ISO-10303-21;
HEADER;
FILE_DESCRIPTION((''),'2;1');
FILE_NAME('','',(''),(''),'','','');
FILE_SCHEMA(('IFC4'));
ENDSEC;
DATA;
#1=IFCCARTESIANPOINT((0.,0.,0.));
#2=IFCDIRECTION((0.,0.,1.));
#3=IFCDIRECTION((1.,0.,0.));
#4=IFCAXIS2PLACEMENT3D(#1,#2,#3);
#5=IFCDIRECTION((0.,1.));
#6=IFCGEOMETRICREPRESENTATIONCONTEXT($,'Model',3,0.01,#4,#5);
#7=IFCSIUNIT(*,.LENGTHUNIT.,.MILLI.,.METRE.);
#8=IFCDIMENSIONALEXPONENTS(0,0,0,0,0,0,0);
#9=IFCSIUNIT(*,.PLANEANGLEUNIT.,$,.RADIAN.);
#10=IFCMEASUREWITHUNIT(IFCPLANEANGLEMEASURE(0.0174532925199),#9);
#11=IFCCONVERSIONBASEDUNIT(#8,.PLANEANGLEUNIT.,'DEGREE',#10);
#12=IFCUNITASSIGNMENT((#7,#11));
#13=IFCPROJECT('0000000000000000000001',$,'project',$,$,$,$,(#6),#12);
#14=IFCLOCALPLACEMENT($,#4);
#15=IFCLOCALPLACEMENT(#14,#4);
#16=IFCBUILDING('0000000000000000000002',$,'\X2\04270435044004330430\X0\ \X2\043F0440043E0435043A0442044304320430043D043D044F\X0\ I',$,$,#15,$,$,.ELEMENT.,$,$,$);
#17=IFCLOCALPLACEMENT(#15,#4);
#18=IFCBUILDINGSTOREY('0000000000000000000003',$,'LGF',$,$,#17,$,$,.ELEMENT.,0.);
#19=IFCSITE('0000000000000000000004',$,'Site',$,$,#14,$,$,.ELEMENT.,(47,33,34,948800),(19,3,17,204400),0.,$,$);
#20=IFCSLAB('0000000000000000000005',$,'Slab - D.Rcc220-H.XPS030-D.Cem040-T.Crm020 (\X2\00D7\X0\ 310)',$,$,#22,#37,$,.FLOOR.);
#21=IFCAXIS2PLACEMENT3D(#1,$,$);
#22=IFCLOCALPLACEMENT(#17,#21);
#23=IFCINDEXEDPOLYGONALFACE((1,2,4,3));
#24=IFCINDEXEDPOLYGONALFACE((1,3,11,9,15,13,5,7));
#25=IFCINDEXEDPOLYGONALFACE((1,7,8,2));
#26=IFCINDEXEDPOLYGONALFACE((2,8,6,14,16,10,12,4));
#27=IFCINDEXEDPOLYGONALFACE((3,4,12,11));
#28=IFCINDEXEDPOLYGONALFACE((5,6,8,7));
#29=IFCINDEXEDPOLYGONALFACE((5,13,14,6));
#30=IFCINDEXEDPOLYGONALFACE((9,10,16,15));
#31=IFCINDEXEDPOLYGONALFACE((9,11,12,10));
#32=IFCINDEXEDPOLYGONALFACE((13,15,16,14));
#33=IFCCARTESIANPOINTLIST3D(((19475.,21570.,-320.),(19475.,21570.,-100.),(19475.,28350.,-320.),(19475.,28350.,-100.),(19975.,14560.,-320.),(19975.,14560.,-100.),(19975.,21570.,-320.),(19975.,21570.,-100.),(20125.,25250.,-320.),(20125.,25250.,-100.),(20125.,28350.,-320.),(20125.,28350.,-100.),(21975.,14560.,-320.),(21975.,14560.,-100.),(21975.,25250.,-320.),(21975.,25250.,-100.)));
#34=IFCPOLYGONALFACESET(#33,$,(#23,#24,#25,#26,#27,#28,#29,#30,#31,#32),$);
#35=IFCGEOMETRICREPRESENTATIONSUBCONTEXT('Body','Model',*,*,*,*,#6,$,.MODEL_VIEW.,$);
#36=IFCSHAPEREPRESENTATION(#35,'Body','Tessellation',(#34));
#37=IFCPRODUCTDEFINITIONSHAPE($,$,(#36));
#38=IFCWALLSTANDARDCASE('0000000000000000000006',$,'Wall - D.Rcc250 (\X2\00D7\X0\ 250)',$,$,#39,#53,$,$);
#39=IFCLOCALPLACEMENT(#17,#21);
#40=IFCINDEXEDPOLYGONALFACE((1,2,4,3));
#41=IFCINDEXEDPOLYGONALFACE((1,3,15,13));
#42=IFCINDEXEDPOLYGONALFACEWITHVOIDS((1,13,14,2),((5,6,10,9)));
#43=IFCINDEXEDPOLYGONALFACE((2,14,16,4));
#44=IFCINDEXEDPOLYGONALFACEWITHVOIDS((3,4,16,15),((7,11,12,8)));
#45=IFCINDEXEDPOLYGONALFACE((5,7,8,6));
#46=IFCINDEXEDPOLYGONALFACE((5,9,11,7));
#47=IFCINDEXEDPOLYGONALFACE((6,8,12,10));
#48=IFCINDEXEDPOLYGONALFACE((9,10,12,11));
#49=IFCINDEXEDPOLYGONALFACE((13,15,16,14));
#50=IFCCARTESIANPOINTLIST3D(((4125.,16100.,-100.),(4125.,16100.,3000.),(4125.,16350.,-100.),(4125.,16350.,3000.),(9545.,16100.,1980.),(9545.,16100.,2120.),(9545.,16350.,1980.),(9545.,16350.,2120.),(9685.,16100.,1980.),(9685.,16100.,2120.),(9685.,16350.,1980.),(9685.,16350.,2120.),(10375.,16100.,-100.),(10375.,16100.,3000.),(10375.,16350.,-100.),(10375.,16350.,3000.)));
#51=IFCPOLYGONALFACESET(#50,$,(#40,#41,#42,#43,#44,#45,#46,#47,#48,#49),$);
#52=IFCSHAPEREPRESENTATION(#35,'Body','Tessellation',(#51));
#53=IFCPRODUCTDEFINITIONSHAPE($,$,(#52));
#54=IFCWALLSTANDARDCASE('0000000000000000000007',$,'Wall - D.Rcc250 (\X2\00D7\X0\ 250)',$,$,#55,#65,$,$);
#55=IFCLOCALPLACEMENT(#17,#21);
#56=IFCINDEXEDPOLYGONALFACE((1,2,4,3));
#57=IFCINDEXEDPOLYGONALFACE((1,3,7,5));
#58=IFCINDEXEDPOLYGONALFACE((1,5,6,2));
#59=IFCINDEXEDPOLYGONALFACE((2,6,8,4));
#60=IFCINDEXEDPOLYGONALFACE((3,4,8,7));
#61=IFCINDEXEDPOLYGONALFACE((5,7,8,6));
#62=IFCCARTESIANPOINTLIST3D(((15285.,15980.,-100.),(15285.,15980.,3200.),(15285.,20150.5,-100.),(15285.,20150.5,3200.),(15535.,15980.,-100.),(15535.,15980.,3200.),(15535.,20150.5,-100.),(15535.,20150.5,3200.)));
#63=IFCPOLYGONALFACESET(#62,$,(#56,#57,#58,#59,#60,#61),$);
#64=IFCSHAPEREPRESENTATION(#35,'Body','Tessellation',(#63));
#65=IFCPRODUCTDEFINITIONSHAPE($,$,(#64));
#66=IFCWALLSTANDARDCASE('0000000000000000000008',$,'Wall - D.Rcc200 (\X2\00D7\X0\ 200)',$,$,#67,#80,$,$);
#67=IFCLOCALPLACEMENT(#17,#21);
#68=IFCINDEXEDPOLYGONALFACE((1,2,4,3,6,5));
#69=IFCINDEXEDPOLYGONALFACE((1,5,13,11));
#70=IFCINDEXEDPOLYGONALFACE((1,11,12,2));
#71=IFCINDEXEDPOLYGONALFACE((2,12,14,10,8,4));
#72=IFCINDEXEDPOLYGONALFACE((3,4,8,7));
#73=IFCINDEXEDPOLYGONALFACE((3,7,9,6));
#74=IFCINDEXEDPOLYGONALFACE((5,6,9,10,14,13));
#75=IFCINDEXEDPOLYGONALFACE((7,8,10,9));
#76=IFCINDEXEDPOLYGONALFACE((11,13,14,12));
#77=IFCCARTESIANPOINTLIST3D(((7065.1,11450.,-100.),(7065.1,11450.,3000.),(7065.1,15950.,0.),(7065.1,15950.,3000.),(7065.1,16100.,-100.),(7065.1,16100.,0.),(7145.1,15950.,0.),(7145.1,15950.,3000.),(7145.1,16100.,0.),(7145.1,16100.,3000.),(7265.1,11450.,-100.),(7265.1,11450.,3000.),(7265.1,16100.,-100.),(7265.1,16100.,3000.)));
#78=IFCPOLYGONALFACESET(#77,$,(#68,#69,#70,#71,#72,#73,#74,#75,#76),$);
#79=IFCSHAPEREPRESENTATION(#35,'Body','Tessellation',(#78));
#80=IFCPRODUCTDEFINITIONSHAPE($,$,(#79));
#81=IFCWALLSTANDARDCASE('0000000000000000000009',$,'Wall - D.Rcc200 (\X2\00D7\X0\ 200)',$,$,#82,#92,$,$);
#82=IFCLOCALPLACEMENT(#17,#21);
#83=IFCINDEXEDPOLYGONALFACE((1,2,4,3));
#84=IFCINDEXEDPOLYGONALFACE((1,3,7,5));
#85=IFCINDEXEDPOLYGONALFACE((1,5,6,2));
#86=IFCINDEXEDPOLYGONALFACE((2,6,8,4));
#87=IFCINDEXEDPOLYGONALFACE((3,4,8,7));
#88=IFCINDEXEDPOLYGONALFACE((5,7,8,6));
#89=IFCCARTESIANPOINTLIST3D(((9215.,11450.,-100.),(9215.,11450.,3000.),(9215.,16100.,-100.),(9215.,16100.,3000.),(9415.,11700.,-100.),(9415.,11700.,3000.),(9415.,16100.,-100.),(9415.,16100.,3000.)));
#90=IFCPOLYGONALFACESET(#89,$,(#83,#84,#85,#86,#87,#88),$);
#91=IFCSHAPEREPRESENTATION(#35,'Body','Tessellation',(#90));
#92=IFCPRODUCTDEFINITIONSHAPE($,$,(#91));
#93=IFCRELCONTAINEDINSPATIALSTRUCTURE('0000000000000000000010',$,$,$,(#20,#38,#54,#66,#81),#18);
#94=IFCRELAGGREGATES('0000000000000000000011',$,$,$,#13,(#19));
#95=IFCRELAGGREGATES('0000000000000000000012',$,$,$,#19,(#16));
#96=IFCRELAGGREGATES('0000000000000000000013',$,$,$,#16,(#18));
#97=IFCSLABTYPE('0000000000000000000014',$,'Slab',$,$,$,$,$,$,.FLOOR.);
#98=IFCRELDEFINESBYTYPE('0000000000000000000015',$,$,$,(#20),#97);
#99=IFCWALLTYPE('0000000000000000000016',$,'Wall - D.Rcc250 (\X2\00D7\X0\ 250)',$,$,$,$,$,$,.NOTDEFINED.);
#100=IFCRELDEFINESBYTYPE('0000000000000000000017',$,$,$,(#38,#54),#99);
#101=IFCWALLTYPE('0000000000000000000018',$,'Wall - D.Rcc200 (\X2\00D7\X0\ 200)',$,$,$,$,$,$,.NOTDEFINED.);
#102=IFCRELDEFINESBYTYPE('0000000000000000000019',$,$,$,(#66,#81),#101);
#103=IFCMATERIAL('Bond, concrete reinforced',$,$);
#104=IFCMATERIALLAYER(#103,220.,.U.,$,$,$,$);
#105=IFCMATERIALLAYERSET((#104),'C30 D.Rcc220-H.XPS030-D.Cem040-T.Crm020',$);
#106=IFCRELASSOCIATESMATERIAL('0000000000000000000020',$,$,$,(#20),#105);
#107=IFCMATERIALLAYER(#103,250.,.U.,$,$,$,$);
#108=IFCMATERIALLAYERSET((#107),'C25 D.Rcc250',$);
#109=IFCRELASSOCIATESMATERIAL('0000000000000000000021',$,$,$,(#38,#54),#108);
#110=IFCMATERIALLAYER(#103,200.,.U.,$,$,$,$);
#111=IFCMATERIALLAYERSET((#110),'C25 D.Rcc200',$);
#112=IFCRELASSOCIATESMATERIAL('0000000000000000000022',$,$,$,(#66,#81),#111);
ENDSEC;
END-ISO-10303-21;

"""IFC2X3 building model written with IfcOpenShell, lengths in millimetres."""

from ifc_helpers import new_model, entity, si_unit, converted_unit, direction, frame, origin_with_axes, origin_2d_with_axis, place, context, subcontext, project, spatial, polyline, rectangle, outline, extrude, material, layer, layer_set, layer_usage, type_object, element, save


model = new_model("IFC2X3")

# Units and contexts
model_context = context("Model", 3, precision=0.01, world=origin_with_axes(), true_north=direction((0.0, 1.0)))
body_context = subcontext(model_context, "Body", "Model", "MODEL_VIEW")
ifc_project = project(units=[si_unit("LENGTHUNIT", "METRE", prefix="MILLI"), converted_unit("PLANEANGLEUNIT", "DEGREE", entity("IfcPlaneAngleMeasure", 0.0174532925199), si_unit("PLANEANGLEUNIT", "RADIAN"), dimensions=[0, 0, 0, 0, 0, 0, 0])], contexts=[model_context])

# Site, building, storey
site_placement = place(None, origin_with_axes())
site = spatial("IfcSite", under=ifc_project, at=site_placement, Name="Site", CompositionType="ELEMENT", RefLatitude=(47, 33, 34, 948800), RefLongitude=(19, 3, 17, 204400), RefElevation=0.0)
building_placement = place(site_placement, origin_with_axes())
building = spatial("IfcBuilding", under=site, at=building_placement, Name="Черга проектування I", CompositionType="ELEMENT")
storey_placement = place(building_placement, origin_with_axes())
storey = spatial("IfcBuildingStorey", under=building, at=storey_placement, Name="LGF", CompositionType="ELEMENT", Elevation=0.0)

# Shared definitions
ifc_material = material(Name="Bond, concrete reinforced")

# Slab
ifc_layer_1 = layer(ifc_material, 220.0, ventilated="UNKNOWN")
ifc_layer_set_1 = layer_set([ifc_layer_1], Name="C30 D.Rcc220-H.XPS030-D.Cem040-T.Crm020")
ifc_layer_usage_1 = layer_usage(ifc_layer_set_1, "AXIS3", "NEGATIVE", 220.0)
slab_type = type_object("IfcSlabType", Name="Slab", PredefinedType="FLOOR")
slab_placement = place(storey_placement, frame((19475.0, 21570.0, -100.0), z_axis=(0.0, 0.0, 1.0), x_axis=(1.0, 0.0, 0.0)))
element("IfcSlab", 1, at=slab_placement, inside=storey, type_object=slab_type, material=ifc_layer_usage_1, Name="Slab - D.Rcc220-H.XPS030-D.Cem040-T.Crm020 (× 310)", PredefinedType="FLOOR", context=body_context, shape_type="SweptSolid", body=[
    extrude(outline(polyline([(0.0, 0.0), (500.0, 0.0), (500.0, -7010.0), (2500.0, -7010.0), (2500.0, 3680.0), (650.0, 3680.0), (650.0, 6780.0), (0.0, 6780.0), (0.0, 0.0)])), frame((0.0, 0.0, -220.0), z_axis=(0.0, 0.0, 1.0), x_axis=(1.0, 0.0, 0.0)), (0.0, 0.0, 1.0), 220.0),
])

# Wall, opening
ifc_layer_2 = layer(ifc_material, 250.0, ventilated="UNKNOWN")
ifc_layer_set_2 = layer_set([ifc_layer_2], Name="C25 D.Rcc250")
ifc_layer_usage_2 = layer_usage(ifc_layer_set_2, "AXIS2", "POSITIVE", -250.0)
wall_type_1 = type_object("IfcWallType", Name="Wall - D.Rcc250 (× 250)", PredefinedType="NOTDEFINED")
wall_1_placement = place(storey_placement, frame((10375.0, 16100.0, -100.0), z_axis=(0.0, 0.0, 1.0), x_axis=(-1.0, 0.0, 0.0)))
wall_1 = element("IfcWallStandardCase", 2, at=wall_1_placement, inside=storey, type_object=wall_type_1, material=ifc_layer_usage_2, Name="Wall - D.Rcc250 (× 250)", context=body_context, shape_type="SweptSolid", body=[
    extrude(outline(polyline([(0.0, -250.0), (6250.0, -250.0), (6250.0, 0.0), (0.0, 0.0), (0.0, -250.0)])), origin_with_axes(), (0.0, 0.0, 1.0), 3100.0),
])
opening_1_placement = place(wall_1_placement, frame((10375.0, 16100.0, 100.0), z_axis=(0.0, 0.0, 1.0), x_axis=(-1.0, 0.0, 0.0)))
element("IfcOpeningElement", 3, at=opening_1_placement, cuts=wall_1, ObjectType="OPENING", context=body_context, shape_type="SweptSolid", body=[
    extrude(rectangle(XDim=140.0, YDim=140.0, at=origin_2d_with_axis()), frame((9615.0, 16600.0, 2050.0), z_axis=(0.0, 1.0, 0.0), x_axis=(-1.0, 0.0, 0.0)), (0.0, 0.0, -1.0), 750.0),
])

# Wall
ifc_layer_usage_3 = layer_usage(ifc_layer_set_2, "AXIS2", "NEGATIVE", 250.0)
wall_2_placement = place(storey_placement, frame((15535.0, 15980.0, -100.0), z_axis=(0.0, 0.0, 1.0), x_axis=(0.0, 1.0, 0.0)))
element("IfcWallStandardCase", 4, at=wall_2_placement, inside=storey, type_object=wall_type_1, material=ifc_layer_usage_3, Name="Wall - D.Rcc250 (× 250)", context=body_context, shape_type="SweptSolid", body=[
    extrude(outline(polyline([(0.0, 0.0), (4170.4, 0.0), (4170.4, 250.0), (0.0, 250.0), (0.0, 0.0)])), origin_with_axes(), (0.0, 0.0, 1.0), 3300.0),
])

# Wall, opening
ifc_layer_3 = layer(ifc_material, 200.0, ventilated="UNKNOWN")
ifc_layer_set_3 = layer_set([ifc_layer_3], Name="C25 D.Rcc200")
ifc_layer_usage_4 = layer_usage(ifc_layer_set_3, "AXIS2", "POSITIVE", -200.0)
wall_type_2 = type_object("IfcWallType", Name="Wall - D.Rcc200 (× 200)", PredefinedType="NOTDEFINED")
wall_3_placement = place(storey_placement, frame((7265.1, 16100.0, -100.0), z_axis=(0.0, 0.0, 1.0), x_axis=(0.0, -1.0, 0.0)))
wall_3 = element("IfcWallStandardCase", 5, at=wall_3_placement, inside=storey, type_object=wall_type_2, material=ifc_layer_usage_4, Name="Wall - D.Rcc200 (× 200)", context=body_context, shape_type="SweptSolid", body=[
    extrude(outline(polyline([(0.0, -200.0), (4650.0, -200.0), (4650.0, 0.0), (0.0, 0.0), (0.0, -200.0)])), origin_with_axes(), (0.0, 0.0, 1.0), 3100.0),
])
opening_2_placement = place(wall_3_placement, frame((16100.0, -7265.1, 100.0), z_axis=(0.0, 0.0, 1.0), x_axis=(0.0, 1.0, 0.0)))
element("IfcOpeningElement", 6, at=opening_2_placement, cuts=wall_3, ObjectType="OPENING", context=body_context, shape_type="SweptSolid", body=[
    extrude(rectangle(XDim=150.0, YDim=3300.0, at=origin_2d_with_axis()), frame((7145.1, 16025.0, 1650.0), z_axis=(-1.0, 0.0, 0.0), x_axis=(0.0, -1.0, 0.0)), (0.0, 0.0, 1.0), 80.0),
])

# Wall
ifc_layer_usage_5 = layer_usage(ifc_layer_set_3, "AXIS2", "POSITIVE", -200.0)
wall_4_placement = place(storey_placement, frame((9415.0, 16100.0, -100.0), z_axis=(0.0, 0.0, 1.0), x_axis=(0.0, -1.0, 0.0)))
element("IfcWallStandardCase", 7, at=wall_4_placement, inside=storey, type_object=wall_type_2, material=ifc_layer_usage_5, Name="Wall - D.Rcc200 (× 200)", context=body_context, shape_type="SweptSolid", body=[
    extrude(outline(polyline([(0.0, -200.0), (4650.0, -200.0), (4400.0, 0.0), (0.0, 0.0), (0.0, -200.0)])), origin_with_axes(), (0.0, 0.0, 1.0), 3100.0),
])

save(model, "model.ifc")
